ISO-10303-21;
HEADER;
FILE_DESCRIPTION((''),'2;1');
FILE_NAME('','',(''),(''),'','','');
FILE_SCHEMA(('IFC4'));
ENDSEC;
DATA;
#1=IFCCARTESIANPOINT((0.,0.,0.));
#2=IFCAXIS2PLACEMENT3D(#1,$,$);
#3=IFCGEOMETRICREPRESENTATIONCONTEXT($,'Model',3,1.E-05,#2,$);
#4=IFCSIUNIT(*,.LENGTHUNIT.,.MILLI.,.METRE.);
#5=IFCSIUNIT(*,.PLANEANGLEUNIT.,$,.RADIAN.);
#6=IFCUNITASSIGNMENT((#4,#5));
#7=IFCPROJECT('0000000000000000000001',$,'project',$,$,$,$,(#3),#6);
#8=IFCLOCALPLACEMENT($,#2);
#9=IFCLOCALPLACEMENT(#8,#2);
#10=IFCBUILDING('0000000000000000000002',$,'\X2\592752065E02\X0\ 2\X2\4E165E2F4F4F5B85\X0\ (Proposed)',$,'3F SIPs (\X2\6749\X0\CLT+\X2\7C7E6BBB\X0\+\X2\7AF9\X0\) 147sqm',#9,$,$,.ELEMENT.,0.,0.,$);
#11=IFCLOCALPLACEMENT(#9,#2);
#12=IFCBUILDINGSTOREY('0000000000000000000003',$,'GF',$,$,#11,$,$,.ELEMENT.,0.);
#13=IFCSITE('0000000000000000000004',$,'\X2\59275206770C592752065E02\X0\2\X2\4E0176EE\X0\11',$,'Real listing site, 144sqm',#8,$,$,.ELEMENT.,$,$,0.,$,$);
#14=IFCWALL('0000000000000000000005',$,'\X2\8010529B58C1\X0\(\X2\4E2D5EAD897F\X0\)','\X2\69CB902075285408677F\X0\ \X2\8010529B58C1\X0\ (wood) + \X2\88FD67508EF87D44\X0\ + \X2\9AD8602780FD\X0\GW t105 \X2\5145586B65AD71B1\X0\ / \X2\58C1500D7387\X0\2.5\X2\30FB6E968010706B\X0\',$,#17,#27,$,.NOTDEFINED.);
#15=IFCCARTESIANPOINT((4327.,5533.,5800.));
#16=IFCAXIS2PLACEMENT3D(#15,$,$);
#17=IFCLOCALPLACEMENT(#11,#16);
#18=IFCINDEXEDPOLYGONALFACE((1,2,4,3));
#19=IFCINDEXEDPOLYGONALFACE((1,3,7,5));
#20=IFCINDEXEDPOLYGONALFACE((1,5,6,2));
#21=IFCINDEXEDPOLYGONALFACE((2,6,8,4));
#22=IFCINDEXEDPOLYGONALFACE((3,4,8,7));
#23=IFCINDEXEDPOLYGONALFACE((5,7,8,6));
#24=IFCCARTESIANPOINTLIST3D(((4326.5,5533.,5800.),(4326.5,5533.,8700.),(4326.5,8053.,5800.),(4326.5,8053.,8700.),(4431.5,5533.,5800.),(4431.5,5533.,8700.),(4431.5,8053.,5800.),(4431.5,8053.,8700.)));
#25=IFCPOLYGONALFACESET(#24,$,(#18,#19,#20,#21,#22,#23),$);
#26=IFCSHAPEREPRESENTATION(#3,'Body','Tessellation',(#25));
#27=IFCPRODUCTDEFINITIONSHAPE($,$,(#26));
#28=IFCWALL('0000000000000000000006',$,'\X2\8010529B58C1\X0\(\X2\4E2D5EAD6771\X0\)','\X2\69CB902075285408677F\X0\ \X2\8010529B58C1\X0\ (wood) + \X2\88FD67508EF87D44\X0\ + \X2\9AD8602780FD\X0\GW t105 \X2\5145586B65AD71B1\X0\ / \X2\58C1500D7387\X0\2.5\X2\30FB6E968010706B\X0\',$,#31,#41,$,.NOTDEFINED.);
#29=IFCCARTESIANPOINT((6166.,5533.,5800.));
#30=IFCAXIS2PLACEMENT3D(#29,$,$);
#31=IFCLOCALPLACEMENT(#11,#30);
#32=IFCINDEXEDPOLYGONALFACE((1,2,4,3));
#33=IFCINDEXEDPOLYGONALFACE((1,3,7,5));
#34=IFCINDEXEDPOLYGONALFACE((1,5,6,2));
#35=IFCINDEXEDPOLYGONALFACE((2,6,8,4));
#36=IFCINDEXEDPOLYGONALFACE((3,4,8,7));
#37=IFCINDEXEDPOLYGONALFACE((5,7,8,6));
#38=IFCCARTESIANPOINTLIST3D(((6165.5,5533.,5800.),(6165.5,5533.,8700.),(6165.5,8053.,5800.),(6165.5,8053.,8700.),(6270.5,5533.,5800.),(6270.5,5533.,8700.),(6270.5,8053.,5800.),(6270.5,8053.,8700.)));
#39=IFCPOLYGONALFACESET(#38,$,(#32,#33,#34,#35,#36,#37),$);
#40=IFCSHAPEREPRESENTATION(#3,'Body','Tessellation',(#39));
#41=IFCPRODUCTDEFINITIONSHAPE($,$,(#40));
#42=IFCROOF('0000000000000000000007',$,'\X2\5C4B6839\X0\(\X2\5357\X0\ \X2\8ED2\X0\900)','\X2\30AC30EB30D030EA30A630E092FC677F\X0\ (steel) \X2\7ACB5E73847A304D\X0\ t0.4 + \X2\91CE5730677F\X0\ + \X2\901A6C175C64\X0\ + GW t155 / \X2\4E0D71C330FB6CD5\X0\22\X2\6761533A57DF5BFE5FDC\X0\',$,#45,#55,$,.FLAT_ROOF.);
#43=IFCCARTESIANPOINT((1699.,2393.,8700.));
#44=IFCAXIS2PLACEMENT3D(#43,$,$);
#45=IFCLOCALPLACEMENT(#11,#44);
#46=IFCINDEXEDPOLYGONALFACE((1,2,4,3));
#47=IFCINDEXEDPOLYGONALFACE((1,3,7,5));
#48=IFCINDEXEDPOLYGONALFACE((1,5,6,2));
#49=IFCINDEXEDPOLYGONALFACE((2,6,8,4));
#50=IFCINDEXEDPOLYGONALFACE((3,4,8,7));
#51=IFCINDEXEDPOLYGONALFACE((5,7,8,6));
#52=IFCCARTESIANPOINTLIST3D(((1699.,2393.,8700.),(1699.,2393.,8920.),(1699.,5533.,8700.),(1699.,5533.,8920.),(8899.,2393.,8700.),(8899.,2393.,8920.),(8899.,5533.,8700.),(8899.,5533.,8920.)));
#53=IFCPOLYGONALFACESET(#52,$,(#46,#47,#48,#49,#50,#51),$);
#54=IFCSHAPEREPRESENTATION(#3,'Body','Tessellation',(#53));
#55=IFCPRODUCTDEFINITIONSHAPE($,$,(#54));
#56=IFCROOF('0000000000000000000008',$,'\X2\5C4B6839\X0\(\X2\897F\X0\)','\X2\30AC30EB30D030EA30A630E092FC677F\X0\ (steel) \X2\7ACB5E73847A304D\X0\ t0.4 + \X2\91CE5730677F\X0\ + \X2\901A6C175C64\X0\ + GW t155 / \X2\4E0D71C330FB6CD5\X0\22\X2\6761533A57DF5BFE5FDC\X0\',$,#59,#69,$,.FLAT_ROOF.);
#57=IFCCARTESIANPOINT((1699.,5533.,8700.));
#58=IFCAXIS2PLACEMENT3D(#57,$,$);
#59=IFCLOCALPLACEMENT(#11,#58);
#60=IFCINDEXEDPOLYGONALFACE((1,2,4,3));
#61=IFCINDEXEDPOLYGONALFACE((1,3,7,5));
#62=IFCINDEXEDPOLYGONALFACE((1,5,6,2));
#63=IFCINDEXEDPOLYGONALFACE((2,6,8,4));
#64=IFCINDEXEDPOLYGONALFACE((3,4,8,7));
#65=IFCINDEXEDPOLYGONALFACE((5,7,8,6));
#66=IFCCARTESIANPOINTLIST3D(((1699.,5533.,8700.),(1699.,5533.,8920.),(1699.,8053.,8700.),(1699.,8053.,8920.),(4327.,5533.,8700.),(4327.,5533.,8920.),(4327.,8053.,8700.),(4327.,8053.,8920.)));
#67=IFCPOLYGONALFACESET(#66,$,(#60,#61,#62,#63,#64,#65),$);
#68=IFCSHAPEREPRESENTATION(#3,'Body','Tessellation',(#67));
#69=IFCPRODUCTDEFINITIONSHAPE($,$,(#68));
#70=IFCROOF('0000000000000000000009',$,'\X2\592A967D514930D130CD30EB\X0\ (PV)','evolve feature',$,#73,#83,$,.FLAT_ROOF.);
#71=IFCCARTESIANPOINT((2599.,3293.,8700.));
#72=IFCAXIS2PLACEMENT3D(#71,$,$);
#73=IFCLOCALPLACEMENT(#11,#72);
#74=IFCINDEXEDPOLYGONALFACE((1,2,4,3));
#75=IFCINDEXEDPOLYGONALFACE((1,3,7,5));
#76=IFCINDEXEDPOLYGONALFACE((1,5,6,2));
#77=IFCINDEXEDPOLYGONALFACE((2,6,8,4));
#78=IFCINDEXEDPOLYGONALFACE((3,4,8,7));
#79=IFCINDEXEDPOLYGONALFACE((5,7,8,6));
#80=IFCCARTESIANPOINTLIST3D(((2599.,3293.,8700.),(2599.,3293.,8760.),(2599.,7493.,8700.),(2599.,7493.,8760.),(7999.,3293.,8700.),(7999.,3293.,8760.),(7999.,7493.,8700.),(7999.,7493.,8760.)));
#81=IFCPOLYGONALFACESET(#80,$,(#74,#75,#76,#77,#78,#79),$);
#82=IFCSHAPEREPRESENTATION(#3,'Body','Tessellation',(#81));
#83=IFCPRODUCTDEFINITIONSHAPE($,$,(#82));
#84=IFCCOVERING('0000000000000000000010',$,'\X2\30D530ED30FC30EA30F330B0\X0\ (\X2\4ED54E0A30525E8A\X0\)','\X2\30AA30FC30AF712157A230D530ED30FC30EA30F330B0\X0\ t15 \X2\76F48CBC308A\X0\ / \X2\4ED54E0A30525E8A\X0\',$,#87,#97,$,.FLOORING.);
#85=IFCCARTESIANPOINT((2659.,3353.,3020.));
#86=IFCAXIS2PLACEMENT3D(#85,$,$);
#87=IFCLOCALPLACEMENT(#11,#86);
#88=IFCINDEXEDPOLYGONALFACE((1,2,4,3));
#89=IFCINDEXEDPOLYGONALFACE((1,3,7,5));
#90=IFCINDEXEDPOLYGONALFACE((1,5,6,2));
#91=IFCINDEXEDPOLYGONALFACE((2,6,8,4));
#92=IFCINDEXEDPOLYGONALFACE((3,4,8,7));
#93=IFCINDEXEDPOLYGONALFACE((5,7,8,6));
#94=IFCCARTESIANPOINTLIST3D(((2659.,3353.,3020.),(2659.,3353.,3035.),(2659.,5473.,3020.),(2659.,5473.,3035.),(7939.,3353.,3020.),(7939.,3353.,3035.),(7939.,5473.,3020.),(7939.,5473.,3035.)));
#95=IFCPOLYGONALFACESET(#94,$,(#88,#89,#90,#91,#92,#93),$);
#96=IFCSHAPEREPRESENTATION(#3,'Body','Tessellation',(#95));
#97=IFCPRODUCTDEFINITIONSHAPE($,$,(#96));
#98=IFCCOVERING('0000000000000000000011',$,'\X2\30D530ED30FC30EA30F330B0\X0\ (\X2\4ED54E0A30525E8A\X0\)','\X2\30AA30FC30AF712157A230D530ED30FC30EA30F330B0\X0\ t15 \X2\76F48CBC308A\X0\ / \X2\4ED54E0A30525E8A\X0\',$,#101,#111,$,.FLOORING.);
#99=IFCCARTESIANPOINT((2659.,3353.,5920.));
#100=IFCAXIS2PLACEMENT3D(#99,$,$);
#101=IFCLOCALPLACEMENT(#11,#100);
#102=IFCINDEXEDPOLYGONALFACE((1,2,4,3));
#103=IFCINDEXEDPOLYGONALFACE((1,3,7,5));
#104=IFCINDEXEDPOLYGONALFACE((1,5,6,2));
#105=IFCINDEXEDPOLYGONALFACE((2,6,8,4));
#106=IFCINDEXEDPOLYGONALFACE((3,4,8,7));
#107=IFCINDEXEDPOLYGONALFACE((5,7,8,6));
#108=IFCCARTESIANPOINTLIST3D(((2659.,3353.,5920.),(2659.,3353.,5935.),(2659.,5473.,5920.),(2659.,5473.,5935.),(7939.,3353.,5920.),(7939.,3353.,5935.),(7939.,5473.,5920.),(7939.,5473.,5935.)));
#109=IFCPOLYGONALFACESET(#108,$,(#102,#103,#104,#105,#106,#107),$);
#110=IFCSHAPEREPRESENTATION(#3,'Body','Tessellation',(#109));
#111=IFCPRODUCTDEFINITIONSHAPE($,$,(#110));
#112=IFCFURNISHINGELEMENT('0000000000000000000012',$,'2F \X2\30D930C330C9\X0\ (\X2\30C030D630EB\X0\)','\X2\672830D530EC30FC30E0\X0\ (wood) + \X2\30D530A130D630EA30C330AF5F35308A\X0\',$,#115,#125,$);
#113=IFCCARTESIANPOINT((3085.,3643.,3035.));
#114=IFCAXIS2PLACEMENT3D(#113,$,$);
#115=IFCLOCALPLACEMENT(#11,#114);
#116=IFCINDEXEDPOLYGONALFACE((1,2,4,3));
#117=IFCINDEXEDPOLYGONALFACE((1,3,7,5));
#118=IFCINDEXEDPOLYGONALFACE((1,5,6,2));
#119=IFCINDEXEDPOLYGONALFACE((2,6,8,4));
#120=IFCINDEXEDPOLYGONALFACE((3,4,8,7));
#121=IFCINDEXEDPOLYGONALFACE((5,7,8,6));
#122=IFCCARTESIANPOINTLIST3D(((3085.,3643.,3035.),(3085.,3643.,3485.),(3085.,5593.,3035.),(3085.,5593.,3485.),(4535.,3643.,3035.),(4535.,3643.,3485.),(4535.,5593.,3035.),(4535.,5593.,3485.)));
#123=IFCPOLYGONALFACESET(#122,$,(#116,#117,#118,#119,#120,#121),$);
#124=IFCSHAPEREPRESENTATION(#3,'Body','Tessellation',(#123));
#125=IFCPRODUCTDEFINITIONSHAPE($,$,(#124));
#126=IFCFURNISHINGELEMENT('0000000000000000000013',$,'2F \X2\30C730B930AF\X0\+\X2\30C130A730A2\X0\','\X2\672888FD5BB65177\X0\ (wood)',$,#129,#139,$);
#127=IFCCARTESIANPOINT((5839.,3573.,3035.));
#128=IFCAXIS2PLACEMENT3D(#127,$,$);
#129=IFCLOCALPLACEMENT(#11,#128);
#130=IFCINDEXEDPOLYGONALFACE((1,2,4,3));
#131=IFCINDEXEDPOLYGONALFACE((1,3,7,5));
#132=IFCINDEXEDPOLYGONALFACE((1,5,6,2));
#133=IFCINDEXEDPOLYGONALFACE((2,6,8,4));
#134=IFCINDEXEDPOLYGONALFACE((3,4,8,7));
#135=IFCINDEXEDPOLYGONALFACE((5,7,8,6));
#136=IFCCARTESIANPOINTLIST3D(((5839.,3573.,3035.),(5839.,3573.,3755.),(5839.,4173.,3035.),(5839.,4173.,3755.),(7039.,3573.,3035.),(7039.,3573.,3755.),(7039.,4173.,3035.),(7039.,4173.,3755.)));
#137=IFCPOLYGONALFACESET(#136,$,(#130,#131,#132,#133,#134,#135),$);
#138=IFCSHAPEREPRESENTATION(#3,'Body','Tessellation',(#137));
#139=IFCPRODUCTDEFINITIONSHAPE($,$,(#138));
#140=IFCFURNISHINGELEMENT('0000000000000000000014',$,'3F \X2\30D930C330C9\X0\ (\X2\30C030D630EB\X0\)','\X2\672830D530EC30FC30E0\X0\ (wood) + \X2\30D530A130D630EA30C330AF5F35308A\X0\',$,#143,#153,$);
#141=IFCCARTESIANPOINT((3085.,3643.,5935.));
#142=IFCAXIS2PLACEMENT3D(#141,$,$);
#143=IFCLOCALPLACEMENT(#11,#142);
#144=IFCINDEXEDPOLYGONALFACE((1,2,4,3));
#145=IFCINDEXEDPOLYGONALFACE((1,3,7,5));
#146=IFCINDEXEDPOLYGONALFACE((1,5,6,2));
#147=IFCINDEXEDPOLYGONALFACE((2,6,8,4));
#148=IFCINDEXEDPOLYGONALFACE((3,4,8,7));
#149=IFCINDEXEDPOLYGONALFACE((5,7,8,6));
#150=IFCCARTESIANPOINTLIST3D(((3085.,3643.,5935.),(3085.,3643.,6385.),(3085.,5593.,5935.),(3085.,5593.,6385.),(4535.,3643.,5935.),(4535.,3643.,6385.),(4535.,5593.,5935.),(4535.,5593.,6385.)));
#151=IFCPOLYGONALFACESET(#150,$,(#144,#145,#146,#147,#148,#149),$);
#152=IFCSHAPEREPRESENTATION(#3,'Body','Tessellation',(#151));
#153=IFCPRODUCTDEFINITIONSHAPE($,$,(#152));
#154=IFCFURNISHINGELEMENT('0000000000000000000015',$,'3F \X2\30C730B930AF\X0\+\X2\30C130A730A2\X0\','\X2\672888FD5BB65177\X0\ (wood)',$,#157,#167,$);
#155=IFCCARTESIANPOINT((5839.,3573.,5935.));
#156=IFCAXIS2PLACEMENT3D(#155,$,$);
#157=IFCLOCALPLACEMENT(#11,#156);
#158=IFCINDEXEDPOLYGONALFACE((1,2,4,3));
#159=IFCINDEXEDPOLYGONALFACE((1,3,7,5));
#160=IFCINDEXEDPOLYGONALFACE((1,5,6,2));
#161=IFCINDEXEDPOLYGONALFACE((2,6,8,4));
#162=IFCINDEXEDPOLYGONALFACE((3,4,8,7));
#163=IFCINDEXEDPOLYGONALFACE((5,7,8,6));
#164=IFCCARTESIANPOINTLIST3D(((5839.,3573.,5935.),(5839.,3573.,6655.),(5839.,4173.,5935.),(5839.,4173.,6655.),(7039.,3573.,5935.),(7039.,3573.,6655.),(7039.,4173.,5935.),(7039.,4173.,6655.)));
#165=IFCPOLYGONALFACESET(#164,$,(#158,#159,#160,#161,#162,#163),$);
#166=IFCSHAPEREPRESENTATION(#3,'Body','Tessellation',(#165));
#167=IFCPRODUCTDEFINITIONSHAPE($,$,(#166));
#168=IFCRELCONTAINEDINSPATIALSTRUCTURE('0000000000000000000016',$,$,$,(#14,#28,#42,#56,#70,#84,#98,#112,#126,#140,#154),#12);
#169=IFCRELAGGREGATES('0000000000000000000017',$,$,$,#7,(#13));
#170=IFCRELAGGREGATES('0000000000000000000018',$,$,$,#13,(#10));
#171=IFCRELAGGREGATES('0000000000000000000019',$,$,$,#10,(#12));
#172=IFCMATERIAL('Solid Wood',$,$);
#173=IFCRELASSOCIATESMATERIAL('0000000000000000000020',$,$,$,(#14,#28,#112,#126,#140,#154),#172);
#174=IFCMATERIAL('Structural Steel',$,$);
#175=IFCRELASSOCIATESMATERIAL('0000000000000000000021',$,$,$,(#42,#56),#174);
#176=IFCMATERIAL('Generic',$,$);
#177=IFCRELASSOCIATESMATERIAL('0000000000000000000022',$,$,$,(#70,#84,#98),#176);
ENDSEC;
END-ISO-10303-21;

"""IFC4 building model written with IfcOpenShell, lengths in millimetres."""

from ifc_helpers import new_model, si_unit, frame, frame_2d, origin, place, context, project, spatial, rectangle, extrude, material, element, save


model = new_model("IFC4")

# Units and contexts
model_context = context("Model", 3, precision=1e-05, world=origin())
ifc_project = project(units=[si_unit("LENGTHUNIT", "METRE", prefix="MILLI"), si_unit("PLANEANGLEUNIT", "RADIAN")], contexts=[model_context])

# Site, building, storey
site_placement = place(None, origin())
site = spatial("IfcSite", under=ifc_project, at=site_placement, Name="大分県大分市2丁目11", ObjectType="Real listing site, 144sqm", CompositionType="ELEMENT", RefElevation=0.0)
building_placement = place(site_placement, origin())
building = spatial("IfcBuilding", under=site, at=building_placement, Name="大分市 2世帯住宅 (Proposed)", ObjectType="3F SIPs (杉CLT+籾殻+竹) 147sqm", CompositionType="ELEMENT", ElevationOfRefHeight=0.0, ElevationOfTerrain=0.0)
storey_placement = place(building_placement, origin())
storey = spatial("IfcBuildingStorey", under=building, at=storey_placement, Name="GF", CompositionType="ELEMENT", Elevation=0.0)

# Shared definitions
ifc_material_1 = material(Name="Solid Wood")

# Walls
wall_1_placement = place(storey_placement, frame((4327.0, 5533.0, 5800.0)))
element("IfcWall", 1, at=wall_1_placement, inside=storey, material=ifc_material_1, Name="耐力壁(中庭西)", Description="構造用合板 耐力壁 (wood) + 製材軸組 + 高性能GW t105 充填断熱 / 壁倍率2.5・準耐火", PredefinedType="NOTDEFINED", context=model_context, shape_type="SweptSolid", body=[
    extrude(rectangle(XDim=105.0, YDim=2520.0, at=frame_2d((52.0, 1260.0))), frame((4327.0, 5533.0, 5800.0)), (0.0, 0.0, 1.0), 2900.0),
])
wall_2_placement = place(storey_placement, frame((6166.0, 5533.0, 5800.0)))
element("IfcWall", 2, at=wall_2_placement, inside=storey, material=ifc_material_1, Name="耐力壁(中庭東)", Description="構造用合板 耐力壁 (wood) + 製材軸組 + 高性能GW t105 充填断熱 / 壁倍率2.5・準耐火", PredefinedType="NOTDEFINED", context=model_context, shape_type="SweptSolid", body=[
    extrude(rectangle(XDim=105.0, YDim=2520.0, at=frame_2d((52.0, 1260.0))), frame((6166.0, 5533.0, 5800.0)), (0.0, 0.0, 1.0), 2900.0),
])

# Roofs
ifc_material_2 = material(Name="Structural Steel")
roof_1_placement = place(storey_placement, frame((1699.0, 2393.0, 8700.0)))
element("IfcRoof", 3, at=roof_1_placement, inside=storey, material=ifc_material_2, Name="屋根(南 軒900)", Description="ガルバリウム鋼板 (steel) 立平葺き t0.4 + 野地板 + 通気層 + GW t155 / 不燃・法22条区域対応", PredefinedType="FLAT_ROOF", context=model_context, shape_type="SweptSolid", body=[
    extrude(rectangle(XDim=7200.0, YDim=3140.0, at=frame_2d((3600.0, 1570.0))), frame((1699.0, 2393.0, 8700.0)), (0.0, 0.0, 1.0), 220.0),
])
roof_2_placement = place(storey_placement, frame((1699.0, 5533.0, 8700.0)))
element("IfcRoof", 4, at=roof_2_placement, inside=storey, material=ifc_material_2, Name="屋根(西)", Description="ガルバリウム鋼板 (steel) 立平葺き t0.4 + 野地板 + 通気層 + GW t155 / 不燃・法22条区域対応", PredefinedType="FLAT_ROOF", context=model_context, shape_type="SweptSolid", body=[
    extrude(rectangle(XDim=2628.0, YDim=2520.0, at=frame_2d((1314.0, 1260.0))), frame((1699.0, 5533.0, 8700.0)), (0.0, 0.0, 1.0), 220.0),
])
ifc_material_3 = material(Name="Generic")
roof_3_placement = place(storey_placement, frame((2599.0, 3293.0, 8700.0)))
element("IfcRoof", 5, at=roof_3_placement, inside=storey, material=ifc_material_3, Name="太陽光パネル (PV)", Description="evolve feature", PredefinedType="FLAT_ROOF", context=model_context, shape_type="SweptSolid", body=[
    extrude(rectangle(XDim=5400.0, YDim=4200.0, at=frame_2d((2700.0, 2100.0))), frame((2599.0, 3293.0, 8700.0)), (0.0, 0.0, 1.0), 60.0),
])

# Coverings
covering_1_placement = place(storey_placement, frame((2659.0, 3353.0, 3020.0)))
element("IfcCovering", 6, at=covering_1_placement, inside=storey, material=ifc_material_3, Name="フローリング (仕上げ床)", Description="オーク無垢フローリング t15 直貼り / 仕上げ床", PredefinedType="FLOORING", context=model_context, shape_type="SweptSolid", body=[
    extrude(rectangle(XDim=5280.0, YDim=2120.0, at=frame_2d((2640.0, 1060.0))), frame((2659.0, 3353.0, 3020.0)), (0.0, 0.0, 1.0), 15.0),
])
covering_2_placement = place(storey_placement, frame((2659.0, 3353.0, 5920.0)))
element("IfcCovering", 7, at=covering_2_placement, inside=storey, material=ifc_material_3, Name="フローリング (仕上げ床)", Description="オーク無垢フローリング t15 直貼り / 仕上げ床", PredefinedType="FLOORING", context=model_context, shape_type="SweptSolid", body=[
    extrude(rectangle(XDim=5280.0, YDim=2120.0, at=frame_2d((2640.0, 1060.0))), frame((2659.0, 3353.0, 5920.0)), (0.0, 0.0, 1.0), 15.0),
])

# Furnishing elements
furnishing_1_placement = place(storey_placement, frame((3085.0, 3643.0, 3035.0)))
element("IfcFurnishingElement", 8, at=furnishing_1_placement, inside=storey, material=ifc_material_1, Name="2F ベッド (ダブル)", Description="木フレーム (wood) + ファブリック張り", context=model_context, shape_type="SweptSolid", body=[
    extrude(rectangle(XDim=1450.0, YDim=1950.0, at=frame_2d((725.0, 975.0))), frame((3085.0, 3643.0, 3035.0)), (0.0, 0.0, 1.0), 450.0),
])
furnishing_2_placement = place(storey_placement, frame((5839.0, 3573.0, 3035.0)))
element("IfcFurnishingElement", 9, at=furnishing_2_placement, inside=storey, material=ifc_material_1, Name="2F デスク+チェア", Description="木製家具 (wood)", context=model_context, shape_type="SweptSolid", body=[
    extrude(rectangle(XDim=1200.0, YDim=600.0, at=frame_2d((600.0, 300.0))), frame((5839.0, 3573.0, 3035.0)), (0.0, 0.0, 1.0), 720.0),
])
furnishing_3_placement = place(storey_placement, frame((3085.0, 3643.0, 5935.0)))
element("IfcFurnishingElement", 10, at=furnishing_3_placement, inside=storey, material=ifc_material_1, Name="3F ベッド (ダブル)", Description="木フレーム (wood) + ファブリック張り", context=model_context, shape_type="SweptSolid", body=[
    extrude(rectangle(XDim=1450.0, YDim=1950.0, at=frame_2d((725.0, 975.0))), frame((3085.0, 3643.0, 5935.0)), (0.0, 0.0, 1.0), 450.0),
])
furnishing_4_placement = place(storey_placement, frame((5839.0, 3573.0, 5935.0)))
element("IfcFurnishingElement", 11, at=furnishing_4_placement, inside=storey, material=ifc_material_1, Name="3F デスク+チェア", Description="木製家具 (wood)", context=model_context, shape_type="SweptSolid", body=[
    extrude(rectangle(XDim=1200.0, YDim=600.0, at=frame_2d((600.0, 300.0))), frame((5839.0, 3573.0, 5935.0)), (0.0, 0.0, 1.0), 720.0),
])

save(model, "model.ifc")
